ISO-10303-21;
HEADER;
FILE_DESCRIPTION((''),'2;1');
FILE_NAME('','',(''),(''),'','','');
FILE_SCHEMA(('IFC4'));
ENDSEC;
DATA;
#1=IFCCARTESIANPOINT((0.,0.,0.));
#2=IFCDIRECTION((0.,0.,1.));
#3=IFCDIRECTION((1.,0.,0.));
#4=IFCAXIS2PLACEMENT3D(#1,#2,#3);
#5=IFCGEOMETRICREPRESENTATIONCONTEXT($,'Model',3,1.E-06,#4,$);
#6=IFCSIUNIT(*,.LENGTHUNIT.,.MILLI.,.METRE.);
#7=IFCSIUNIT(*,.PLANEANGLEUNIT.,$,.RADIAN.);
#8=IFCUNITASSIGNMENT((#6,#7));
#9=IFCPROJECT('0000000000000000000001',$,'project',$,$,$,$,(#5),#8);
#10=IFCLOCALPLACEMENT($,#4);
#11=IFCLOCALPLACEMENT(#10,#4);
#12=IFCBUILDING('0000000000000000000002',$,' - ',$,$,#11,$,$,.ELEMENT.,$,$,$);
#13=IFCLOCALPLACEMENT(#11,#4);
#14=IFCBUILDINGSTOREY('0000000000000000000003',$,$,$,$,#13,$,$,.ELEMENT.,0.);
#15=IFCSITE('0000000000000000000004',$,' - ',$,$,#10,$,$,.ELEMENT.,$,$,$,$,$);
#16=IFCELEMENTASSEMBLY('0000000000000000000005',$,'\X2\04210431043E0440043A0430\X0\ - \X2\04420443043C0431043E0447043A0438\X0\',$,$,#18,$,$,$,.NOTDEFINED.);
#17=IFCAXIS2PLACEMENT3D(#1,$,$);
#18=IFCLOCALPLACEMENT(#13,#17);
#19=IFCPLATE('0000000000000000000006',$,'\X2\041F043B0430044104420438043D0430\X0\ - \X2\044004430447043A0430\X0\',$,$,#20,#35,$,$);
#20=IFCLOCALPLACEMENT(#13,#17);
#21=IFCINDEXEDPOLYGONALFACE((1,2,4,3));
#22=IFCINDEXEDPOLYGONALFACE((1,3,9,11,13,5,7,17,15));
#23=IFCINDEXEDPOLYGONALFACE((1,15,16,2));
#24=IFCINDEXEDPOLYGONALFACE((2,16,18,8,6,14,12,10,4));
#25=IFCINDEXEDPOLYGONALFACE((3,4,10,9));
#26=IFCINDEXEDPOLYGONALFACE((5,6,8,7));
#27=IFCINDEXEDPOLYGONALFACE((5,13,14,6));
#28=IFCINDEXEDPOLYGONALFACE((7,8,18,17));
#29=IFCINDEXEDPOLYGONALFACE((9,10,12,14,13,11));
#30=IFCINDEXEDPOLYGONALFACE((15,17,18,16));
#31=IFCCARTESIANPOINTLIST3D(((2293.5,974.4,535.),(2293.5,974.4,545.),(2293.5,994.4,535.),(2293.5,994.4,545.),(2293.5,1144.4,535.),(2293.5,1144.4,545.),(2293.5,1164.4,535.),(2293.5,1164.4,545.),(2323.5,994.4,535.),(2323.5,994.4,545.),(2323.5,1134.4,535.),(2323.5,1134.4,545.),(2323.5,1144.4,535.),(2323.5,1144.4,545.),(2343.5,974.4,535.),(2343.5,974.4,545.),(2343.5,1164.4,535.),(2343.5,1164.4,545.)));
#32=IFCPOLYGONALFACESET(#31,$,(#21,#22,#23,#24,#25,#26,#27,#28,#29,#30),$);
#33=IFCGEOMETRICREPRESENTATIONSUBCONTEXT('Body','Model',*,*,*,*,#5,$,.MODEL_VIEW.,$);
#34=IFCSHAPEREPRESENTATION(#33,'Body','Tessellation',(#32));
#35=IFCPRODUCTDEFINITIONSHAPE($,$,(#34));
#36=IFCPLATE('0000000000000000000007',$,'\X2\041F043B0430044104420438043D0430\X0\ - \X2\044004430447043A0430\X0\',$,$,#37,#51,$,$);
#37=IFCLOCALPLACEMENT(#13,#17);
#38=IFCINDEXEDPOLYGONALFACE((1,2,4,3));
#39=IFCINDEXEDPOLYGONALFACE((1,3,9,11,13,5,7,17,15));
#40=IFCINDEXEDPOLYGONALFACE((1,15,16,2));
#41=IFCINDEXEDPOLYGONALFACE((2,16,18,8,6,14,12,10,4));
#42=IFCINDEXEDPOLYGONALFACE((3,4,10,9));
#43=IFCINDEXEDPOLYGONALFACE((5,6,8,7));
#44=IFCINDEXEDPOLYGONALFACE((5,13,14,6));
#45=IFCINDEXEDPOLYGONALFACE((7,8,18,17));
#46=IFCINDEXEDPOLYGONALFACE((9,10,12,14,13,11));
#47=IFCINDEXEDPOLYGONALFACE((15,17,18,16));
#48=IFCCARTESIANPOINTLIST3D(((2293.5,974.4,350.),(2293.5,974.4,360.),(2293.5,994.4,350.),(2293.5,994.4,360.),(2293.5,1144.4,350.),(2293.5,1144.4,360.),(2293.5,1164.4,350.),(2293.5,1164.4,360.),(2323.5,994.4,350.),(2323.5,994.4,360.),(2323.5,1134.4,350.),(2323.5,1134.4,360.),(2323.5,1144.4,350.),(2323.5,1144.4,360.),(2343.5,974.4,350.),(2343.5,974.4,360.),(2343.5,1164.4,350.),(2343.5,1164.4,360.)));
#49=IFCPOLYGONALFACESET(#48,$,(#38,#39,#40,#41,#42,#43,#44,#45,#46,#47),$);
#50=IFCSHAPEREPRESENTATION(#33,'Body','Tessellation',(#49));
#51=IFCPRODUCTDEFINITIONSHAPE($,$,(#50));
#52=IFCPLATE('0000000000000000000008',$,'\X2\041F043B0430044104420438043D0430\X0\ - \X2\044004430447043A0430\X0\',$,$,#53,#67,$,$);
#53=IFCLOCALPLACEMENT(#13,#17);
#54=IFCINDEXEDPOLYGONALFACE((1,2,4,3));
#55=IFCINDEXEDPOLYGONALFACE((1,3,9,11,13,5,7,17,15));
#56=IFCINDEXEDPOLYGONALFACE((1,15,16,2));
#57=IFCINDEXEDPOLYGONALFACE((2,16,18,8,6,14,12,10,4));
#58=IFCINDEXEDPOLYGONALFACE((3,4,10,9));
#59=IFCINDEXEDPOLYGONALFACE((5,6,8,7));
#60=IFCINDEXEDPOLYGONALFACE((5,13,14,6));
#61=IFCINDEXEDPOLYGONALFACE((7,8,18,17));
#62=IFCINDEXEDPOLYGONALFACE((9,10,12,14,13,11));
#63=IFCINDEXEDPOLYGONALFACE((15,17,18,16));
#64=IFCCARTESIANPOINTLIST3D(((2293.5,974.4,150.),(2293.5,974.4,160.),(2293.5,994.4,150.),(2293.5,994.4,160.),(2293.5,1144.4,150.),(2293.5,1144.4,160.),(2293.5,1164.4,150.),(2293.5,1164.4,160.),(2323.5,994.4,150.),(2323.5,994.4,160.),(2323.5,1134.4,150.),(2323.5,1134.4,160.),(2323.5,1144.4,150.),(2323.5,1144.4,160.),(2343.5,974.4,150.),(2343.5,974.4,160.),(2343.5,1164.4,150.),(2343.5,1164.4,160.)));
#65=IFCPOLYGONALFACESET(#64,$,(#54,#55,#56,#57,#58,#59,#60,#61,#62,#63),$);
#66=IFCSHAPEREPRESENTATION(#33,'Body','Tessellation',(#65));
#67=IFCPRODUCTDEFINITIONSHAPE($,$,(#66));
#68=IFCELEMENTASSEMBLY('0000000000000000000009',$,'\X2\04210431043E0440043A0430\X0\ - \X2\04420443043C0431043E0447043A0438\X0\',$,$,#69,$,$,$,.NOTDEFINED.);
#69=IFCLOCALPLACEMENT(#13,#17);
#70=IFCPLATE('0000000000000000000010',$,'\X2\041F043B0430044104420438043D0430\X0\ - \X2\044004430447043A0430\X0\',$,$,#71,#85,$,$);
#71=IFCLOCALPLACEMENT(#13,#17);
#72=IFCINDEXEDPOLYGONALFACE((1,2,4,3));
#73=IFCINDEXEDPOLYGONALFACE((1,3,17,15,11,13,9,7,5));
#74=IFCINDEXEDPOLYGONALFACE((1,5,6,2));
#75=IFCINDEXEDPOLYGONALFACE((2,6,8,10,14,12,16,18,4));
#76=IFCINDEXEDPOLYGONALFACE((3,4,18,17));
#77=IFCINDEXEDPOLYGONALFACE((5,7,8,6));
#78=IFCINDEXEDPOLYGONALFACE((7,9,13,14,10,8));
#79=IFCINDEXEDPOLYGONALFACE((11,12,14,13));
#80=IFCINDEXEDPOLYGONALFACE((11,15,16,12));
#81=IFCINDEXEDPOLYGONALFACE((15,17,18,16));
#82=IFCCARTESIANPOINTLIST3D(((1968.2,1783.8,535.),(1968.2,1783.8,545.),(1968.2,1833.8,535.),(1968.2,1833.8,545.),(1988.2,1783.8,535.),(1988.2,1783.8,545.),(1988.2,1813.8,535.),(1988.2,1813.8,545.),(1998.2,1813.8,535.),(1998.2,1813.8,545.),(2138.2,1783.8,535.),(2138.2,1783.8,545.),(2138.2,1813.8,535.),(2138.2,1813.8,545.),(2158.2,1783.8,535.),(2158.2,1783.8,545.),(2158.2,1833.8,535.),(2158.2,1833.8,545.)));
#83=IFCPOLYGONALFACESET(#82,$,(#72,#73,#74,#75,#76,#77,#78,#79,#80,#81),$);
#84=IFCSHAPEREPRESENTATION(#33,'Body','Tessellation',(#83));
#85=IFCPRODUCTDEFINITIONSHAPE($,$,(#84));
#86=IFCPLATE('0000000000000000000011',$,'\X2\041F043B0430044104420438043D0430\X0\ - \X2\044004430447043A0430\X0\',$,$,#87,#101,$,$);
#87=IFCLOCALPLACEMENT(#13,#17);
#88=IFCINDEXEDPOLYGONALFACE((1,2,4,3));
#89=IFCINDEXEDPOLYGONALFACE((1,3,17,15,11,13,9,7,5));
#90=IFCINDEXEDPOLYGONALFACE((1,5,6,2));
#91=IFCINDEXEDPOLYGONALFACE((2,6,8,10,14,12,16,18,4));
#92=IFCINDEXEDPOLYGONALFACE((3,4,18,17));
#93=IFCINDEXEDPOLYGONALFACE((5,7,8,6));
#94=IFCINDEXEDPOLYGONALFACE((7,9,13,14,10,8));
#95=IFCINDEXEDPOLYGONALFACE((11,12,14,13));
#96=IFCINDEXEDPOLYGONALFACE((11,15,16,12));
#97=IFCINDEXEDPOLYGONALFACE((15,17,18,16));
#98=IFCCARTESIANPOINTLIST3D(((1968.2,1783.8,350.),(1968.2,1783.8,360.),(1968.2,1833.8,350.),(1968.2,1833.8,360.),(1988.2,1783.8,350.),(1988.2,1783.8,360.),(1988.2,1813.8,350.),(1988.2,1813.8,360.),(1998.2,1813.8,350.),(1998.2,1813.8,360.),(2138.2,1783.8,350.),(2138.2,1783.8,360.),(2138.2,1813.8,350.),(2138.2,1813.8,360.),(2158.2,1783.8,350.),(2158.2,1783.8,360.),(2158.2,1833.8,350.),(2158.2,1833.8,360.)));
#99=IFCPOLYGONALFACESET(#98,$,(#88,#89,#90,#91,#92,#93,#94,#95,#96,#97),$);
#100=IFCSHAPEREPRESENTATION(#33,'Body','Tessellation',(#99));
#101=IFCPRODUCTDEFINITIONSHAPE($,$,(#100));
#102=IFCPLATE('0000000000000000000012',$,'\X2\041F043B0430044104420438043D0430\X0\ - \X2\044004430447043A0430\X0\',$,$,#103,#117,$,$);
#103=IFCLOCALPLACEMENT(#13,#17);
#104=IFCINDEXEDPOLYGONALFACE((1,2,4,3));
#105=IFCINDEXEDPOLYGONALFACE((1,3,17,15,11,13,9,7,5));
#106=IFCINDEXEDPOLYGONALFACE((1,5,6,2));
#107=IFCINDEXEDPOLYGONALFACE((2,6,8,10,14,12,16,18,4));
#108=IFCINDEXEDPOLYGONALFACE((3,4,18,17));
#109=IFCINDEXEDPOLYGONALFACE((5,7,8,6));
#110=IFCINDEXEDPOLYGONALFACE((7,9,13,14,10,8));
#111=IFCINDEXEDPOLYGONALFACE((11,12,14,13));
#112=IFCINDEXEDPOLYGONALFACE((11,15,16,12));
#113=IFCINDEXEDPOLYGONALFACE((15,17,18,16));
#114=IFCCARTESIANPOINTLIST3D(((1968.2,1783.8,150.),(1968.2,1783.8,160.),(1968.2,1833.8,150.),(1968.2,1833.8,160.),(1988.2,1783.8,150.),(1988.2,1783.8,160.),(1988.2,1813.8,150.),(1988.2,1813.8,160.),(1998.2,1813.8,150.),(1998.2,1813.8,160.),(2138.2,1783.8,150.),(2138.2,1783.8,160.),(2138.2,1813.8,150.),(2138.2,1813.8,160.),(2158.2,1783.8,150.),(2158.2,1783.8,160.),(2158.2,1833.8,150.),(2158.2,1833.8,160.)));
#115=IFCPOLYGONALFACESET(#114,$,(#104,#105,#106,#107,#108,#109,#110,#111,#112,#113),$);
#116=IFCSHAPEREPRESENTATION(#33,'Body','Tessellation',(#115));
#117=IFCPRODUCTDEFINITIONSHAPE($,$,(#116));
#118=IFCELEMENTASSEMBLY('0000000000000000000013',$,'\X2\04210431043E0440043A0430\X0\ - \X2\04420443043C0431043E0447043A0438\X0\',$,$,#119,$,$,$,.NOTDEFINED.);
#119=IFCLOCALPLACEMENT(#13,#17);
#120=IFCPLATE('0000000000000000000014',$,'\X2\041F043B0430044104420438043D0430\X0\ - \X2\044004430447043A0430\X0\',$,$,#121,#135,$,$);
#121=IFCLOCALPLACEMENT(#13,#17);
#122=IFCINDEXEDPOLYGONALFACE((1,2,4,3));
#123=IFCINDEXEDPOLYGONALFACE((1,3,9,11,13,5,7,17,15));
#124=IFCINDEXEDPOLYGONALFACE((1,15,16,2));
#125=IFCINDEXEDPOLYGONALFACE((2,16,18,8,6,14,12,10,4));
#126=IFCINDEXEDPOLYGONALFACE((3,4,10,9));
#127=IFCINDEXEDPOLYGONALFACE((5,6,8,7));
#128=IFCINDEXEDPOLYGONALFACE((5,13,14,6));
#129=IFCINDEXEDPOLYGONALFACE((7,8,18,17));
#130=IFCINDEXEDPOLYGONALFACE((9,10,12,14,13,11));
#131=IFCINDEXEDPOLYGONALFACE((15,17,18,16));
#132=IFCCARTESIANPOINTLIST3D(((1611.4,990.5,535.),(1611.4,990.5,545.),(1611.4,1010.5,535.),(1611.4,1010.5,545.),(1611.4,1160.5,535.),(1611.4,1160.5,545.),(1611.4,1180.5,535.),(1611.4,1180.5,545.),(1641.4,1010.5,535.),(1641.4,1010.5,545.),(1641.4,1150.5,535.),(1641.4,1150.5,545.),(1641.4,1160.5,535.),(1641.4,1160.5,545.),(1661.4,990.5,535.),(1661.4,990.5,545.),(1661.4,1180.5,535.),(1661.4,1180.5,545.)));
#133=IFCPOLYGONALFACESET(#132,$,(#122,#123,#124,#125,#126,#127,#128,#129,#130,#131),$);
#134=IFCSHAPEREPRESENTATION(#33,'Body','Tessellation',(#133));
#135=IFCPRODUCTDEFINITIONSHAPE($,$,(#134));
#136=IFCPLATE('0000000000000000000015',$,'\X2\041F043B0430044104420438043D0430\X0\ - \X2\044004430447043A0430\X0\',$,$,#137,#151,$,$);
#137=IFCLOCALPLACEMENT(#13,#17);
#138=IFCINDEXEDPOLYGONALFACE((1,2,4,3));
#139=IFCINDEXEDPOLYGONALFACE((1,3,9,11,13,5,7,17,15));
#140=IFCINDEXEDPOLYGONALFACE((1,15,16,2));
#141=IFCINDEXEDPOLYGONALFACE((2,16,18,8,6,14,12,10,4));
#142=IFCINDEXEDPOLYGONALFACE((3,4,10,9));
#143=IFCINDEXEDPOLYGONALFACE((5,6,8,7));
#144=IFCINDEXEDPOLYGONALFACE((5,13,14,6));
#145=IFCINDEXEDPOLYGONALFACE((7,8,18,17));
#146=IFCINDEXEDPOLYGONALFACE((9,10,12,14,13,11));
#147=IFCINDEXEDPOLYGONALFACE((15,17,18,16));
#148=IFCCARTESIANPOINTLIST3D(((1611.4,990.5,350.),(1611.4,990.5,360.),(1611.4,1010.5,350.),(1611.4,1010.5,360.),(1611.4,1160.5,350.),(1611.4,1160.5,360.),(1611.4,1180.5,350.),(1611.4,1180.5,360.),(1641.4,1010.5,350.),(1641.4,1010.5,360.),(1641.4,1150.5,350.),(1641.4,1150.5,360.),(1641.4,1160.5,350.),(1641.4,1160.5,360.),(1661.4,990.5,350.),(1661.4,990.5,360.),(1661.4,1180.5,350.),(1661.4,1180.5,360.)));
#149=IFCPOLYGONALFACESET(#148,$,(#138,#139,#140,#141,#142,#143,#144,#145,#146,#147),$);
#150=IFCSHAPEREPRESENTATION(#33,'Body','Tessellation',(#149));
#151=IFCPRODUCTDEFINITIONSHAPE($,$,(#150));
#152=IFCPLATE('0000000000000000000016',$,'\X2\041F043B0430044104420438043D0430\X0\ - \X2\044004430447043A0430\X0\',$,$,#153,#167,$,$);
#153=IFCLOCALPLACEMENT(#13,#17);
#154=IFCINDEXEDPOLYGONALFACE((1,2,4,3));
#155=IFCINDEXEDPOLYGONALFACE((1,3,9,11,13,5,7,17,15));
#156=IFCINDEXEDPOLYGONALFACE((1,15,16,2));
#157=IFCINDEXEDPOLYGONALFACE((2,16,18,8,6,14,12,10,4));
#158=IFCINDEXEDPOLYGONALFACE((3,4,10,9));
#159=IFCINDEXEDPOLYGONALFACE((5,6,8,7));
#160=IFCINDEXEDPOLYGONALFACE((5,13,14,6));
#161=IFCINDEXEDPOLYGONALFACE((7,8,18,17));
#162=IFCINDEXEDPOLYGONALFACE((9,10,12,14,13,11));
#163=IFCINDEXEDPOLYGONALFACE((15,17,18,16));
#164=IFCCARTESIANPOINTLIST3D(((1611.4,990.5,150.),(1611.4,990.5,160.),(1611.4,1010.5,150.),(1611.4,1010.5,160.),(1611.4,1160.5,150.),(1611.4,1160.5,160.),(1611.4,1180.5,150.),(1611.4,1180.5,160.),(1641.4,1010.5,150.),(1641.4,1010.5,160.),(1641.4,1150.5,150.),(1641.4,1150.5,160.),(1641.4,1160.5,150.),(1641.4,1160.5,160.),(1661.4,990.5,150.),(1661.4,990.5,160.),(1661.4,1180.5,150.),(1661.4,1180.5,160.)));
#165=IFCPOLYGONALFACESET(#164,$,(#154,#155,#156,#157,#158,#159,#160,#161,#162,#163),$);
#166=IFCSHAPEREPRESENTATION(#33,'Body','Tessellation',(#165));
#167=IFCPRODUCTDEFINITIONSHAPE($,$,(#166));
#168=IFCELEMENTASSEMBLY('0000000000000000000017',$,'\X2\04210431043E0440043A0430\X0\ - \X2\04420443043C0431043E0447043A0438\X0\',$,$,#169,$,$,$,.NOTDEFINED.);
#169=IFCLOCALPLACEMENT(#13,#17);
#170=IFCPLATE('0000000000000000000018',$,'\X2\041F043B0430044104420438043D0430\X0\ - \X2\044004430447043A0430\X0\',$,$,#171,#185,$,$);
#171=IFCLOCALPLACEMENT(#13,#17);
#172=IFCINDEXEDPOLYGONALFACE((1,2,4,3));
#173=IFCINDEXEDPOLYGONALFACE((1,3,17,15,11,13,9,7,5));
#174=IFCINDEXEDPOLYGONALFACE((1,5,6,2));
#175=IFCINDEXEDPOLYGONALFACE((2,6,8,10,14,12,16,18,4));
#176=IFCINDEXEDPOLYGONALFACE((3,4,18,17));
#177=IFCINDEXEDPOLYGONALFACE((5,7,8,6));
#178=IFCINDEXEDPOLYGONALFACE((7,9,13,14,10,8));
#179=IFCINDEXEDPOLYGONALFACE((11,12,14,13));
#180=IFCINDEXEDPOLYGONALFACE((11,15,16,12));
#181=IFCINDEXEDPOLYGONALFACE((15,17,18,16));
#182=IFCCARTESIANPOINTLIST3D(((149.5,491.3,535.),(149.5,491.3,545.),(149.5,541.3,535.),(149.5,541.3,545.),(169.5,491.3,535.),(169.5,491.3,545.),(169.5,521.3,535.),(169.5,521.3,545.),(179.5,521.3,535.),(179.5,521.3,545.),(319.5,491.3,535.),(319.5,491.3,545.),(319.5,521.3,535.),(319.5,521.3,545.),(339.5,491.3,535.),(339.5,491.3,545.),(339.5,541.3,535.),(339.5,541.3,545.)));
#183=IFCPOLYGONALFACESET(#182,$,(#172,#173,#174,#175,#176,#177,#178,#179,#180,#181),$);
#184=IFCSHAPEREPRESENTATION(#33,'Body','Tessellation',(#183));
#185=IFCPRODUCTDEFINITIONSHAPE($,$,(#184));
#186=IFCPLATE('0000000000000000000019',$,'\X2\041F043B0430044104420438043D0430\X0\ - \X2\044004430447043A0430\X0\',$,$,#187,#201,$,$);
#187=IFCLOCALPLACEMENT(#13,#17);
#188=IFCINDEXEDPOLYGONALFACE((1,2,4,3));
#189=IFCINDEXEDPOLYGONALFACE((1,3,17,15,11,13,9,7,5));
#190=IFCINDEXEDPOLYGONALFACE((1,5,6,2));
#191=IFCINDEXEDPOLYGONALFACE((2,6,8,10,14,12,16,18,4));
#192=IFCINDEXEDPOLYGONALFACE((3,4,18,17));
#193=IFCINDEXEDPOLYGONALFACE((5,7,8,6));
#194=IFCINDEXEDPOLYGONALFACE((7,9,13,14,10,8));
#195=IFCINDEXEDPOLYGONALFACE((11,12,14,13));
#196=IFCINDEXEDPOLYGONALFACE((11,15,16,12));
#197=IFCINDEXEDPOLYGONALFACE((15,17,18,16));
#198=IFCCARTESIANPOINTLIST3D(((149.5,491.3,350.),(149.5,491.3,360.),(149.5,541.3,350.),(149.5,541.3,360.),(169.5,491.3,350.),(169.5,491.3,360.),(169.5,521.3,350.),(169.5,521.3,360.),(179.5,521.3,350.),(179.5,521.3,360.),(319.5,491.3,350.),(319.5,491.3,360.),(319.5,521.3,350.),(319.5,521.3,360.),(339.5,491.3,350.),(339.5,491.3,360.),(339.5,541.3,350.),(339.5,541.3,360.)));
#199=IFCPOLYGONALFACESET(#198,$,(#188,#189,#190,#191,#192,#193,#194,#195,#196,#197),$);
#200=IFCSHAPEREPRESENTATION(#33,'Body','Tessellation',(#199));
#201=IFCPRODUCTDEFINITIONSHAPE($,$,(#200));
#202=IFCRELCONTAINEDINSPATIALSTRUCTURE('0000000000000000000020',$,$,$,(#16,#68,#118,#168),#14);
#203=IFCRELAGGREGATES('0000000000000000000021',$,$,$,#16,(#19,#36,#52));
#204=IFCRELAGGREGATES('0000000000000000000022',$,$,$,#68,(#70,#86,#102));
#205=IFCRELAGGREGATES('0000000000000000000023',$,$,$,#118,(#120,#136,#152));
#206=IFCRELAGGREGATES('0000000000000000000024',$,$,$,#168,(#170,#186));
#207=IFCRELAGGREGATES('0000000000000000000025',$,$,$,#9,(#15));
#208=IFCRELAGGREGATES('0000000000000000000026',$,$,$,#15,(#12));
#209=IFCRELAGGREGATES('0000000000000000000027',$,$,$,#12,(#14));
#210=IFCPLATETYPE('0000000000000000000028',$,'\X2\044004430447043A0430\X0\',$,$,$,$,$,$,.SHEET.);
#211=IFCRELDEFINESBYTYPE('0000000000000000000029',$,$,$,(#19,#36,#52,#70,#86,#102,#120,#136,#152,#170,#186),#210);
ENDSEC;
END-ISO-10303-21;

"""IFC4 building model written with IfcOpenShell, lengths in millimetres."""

from ifc_helpers import new_model, si_unit, frame, origin_with_axes, place, context, subcontext, project, spatial, line, indexed_curve, outline, extrude, source, transform, mapped, type_object, element, aggregate, save


model = new_model("IFC4")

# Units and contexts
model_context = context("Model", 3, precision=1e-06, world=origin_with_axes())
body_context = subcontext(model_context, "Body", "Model", "MODEL_VIEW")
ifc_project = project(units=[si_unit("LENGTHUNIT", "METRE", prefix="MILLI"), si_unit("PLANEANGLEUNIT", "RADIAN")], contexts=[model_context])

# Site, building, storey
site_placement = place(None, origin_with_axes())
site = spatial("IfcSite", under=ifc_project, at=site_placement, Name=" - ", CompositionType="ELEMENT")
building_placement = place(site_placement, origin_with_axes())
building = spatial("IfcBuilding", under=site, at=building_placement, Name=" - ", CompositionType="ELEMENT")
storey_placement = place(building_placement, origin_with_axes())
storey = spatial("IfcBuildingStorey", under=building, at=storey_placement, CompositionType="ELEMENT", Elevation=0.0)

# Shared definitions
plate_type = type_object("IfcPlateType", Name="ручка", PredefinedType="SHEET")
shared_shape_1 = source(origin_with_axes(), body_context, "Body", "SweptSolid", [
    extrude(outline(indexed_curve([(-95.0, -25.0), (-75.0, -25.0), (-75.0, 5.0), (-65.0, 5.0), (75.0, 5.0), (75.0, -25.0), (95.0, -25.0), (95.0, 25.0), (-95.0, 25.0)], segments=[line(1, 2), line(2, 3), line(3, 4), line(4, 5), line(5, 6), line(6, 7), line(7, 8), line(8, 9), line(9, 1)])), origin_with_axes(), (0.0, 0.0, 1.0), 10.0),
])

# Element assemblies, plates
assembly_1_placement = place(storey_placement, frame((2293.5, 869.4, 0.0), z_axis=(0.0, 0.0, 1.0), x_axis=(0.0, 1.0, 0.0)))
assembly_1 = element("IfcElementAssembly", 1, at=assembly_1_placement, inside=storey, Name="Сборка - тумбочки", PredefinedType="NOTDEFINED")
plate_1_placement = place(assembly_1_placement, frame((200.0, -25.0, 535.0), z_axis=(0.0, 0.0, 1.0), x_axis=(-1.0, 0.0, 0.0)))
plate_1 = element("IfcPlate", 2, at=plate_1_placement, type_object=plate_type, Name="Пластина - ручка", context=body_context, shape_type="MappedRepresentation", body=[
    mapped(shared_shape_1, transform((0.0, 0.0, 0.0), x_axis=(1.0, 0.0, 0.0), y_axis=(0.0, 1.0, 0.0), z_axis=(0.0, 0.0, 1.0), scale=1.0)),
])
plate_2_placement = place(assembly_1_placement, frame((200.0, -25.0, 350.0), z_axis=(0.0, 0.0, 1.0), x_axis=(-1.0, 0.0, 0.0)))
plate_2 = element("IfcPlate", 3, at=plate_2_placement, type_object=plate_type, Name="Пластина - ручка", context=body_context, shape_type="MappedRepresentation", body=[
    mapped(shared_shape_1, transform((0.0, 0.0, 0.0), x_axis=(1.0, 0.0, 0.0), y_axis=(0.0, 1.0, 0.0), z_axis=(0.0, 0.0, 1.0), scale=1.0)),
])
plate_3_placement = place(assembly_1_placement, frame((200.0, -25.0, 150.0), z_axis=(0.0, 0.0, 1.0), x_axis=(-1.0, 0.0, 0.0)))
plate_3 = element("IfcPlate", 4, at=plate_3_placement, type_object=plate_type, Name="Пластина - ручка", context=body_context, shape_type="MappedRepresentation", body=[
    mapped(shared_shape_1, transform((0.0, 0.0, 0.0), x_axis=(1.0, 0.0, 0.0), y_axis=(0.0, 1.0, 0.0), z_axis=(0.0, 0.0, 1.0), scale=1.0)),
])
aggregate(assembly_1, [plate_1, plate_2, plate_3])
assembly_2_placement = place(storey_placement, frame((2263.2, 1783.8, 0.0), z_axis=(0.0, 0.0, 1.0), x_axis=(-1.0, 0.0, 0.0)))
assembly_2 = element("IfcElementAssembly", 5, at=assembly_2_placement, inside=storey, Name="Сборка - тумбочки", PredefinedType="NOTDEFINED")
plate_4_placement = place(assembly_2_placement, frame((200.0, -25.0, 535.0), z_axis=(0.0, 0.0, 1.0), x_axis=(-1.0, 0.0, 0.0)))
plate_4 = element("IfcPlate", 6, at=plate_4_placement, type_object=plate_type, Name="Пластина - ручка", context=body_context, shape_type="MappedRepresentation", body=[
    mapped(shared_shape_1, transform((0.0, 0.0, 0.0), x_axis=(1.0, 0.0, 0.0), y_axis=(0.0, 1.0, 0.0), z_axis=(0.0, 0.0, 1.0), scale=1.0)),
])
plate_5_placement = place(assembly_2_placement, frame((200.0, -25.0, 350.0), z_axis=(0.0, 0.0, 1.0), x_axis=(-1.0, 0.0, 0.0)))
plate_5 = element("IfcPlate", 7, at=plate_5_placement, type_object=plate_type, Name="Пластина - ручка", context=body_context, shape_type="MappedRepresentation", body=[
    mapped(shared_shape_1, transform((0.0, 0.0, 0.0), x_axis=(1.0, 0.0, 0.0), y_axis=(0.0, 1.0, 0.0), z_axis=(0.0, 0.0, 1.0), scale=1.0)),
])
plate_6_placement = place(assembly_2_placement, frame((200.0, -25.0, 150.0), z_axis=(0.0, 0.0, 1.0), x_axis=(-1.0, 0.0, 0.0)))
plate_6 = element("IfcPlate", 8, at=plate_6_placement, type_object=plate_type, Name="Пластина - ручка", context=body_context, shape_type="MappedRepresentation", body=[
    mapped(shared_shape_1, transform((0.0, 0.0, 0.0), x_axis=(1.0, 0.0, 0.0), y_axis=(0.0, 1.0, 0.0), z_axis=(0.0, 0.0, 1.0), scale=1.0)),
])
aggregate(assembly_2, [plate_4, plate_5, plate_6])
assembly_3_placement = place(storey_placement, frame((1611.4, 885.5, 0.0), z_axis=(0.0, 0.0, 1.0), x_axis=(0.0, 1.0, 0.0)))
assembly_3 = element("IfcElementAssembly", 9, at=assembly_3_placement, inside=storey, Name="Сборка - тумбочки", PredefinedType="NOTDEFINED")
plate_7_placement = place(assembly_3_placement, frame((200.0, -25.0, 535.0), z_axis=(0.0, 0.0, 1.0), x_axis=(-1.0, 0.0, 0.0)))
plate_7 = element("IfcPlate", 10, at=plate_7_placement, type_object=plate_type, Name="Пластина - ручка", context=body_context, shape_type="MappedRepresentation", body=[
    mapped(shared_shape_1, transform((0.0, 0.0, 0.0), x_axis=(1.0, 0.0, 0.0), y_axis=(0.0, 1.0, 0.0), z_axis=(0.0, 0.0, 1.0), scale=1.0)),
])
plate_8_placement = place(assembly_3_placement, frame((200.0, -25.0, 350.0), z_axis=(0.0, 0.0, 1.0), x_axis=(-1.0, 0.0, 0.0)))
plate_8 = element("IfcPlate", 11, at=plate_8_placement, type_object=plate_type, Name="Пластина - ручка", context=body_context, shape_type="MappedRepresentation", body=[
    mapped(shared_shape_1, transform((0.0, 0.0, 0.0), x_axis=(1.0, 0.0, 0.0), y_axis=(0.0, 1.0, 0.0), z_axis=(0.0, 0.0, 1.0), scale=1.0)),
])
plate_9_placement = place(assembly_3_placement, frame((200.0, -25.0, 150.0), z_axis=(0.0, 0.0, 1.0), x_axis=(-1.0, 0.0, 0.0)))
plate_9 = element("IfcPlate", 12, at=plate_9_placement, type_object=plate_type, Name="Пластина - ручка", context=body_context, shape_type="MappedRepresentation", body=[
    mapped(shared_shape_1, transform((0.0, 0.0, 0.0), x_axis=(1.0, 0.0, 0.0), y_axis=(0.0, 1.0, 0.0), z_axis=(0.0, 0.0, 1.0), scale=1.0)),
])
aggregate(assembly_3, [plate_7, plate_8, plate_9])
assembly_4_placement = place(storey_placement, frame((444.5, 491.3, 0.0), z_axis=(0.0, 0.0, 1.0), x_axis=(-1.0, 0.0, 0.0)))
assembly_4 = element("IfcElementAssembly", 13, at=assembly_4_placement, inside=storey, Name="Сборка - тумбочки", PredefinedType="NOTDEFINED")
plate_10_placement = place(assembly_4_placement, frame((200.0, -25.0, 535.0), z_axis=(0.0, 0.0, 1.0), x_axis=(-1.0, 0.0, 0.0)))
plate_10 = element("IfcPlate", 14, at=plate_10_placement, type_object=plate_type, Name="Пластина - ручка", context=body_context, shape_type="MappedRepresentation", body=[
    mapped(shared_shape_1, transform((0.0, 0.0, 0.0), x_axis=(1.0, 0.0, 0.0), y_axis=(0.0, 1.0, 0.0), z_axis=(0.0, 0.0, 1.0), scale=1.0)),
])
plate_11_placement = place(assembly_4_placement, frame((200.0, -25.0, 350.0), z_axis=(0.0, 0.0, 1.0), x_axis=(-1.0, 0.0, 0.0)))
plate_11 = element("IfcPlate", 15, at=plate_11_placement, type_object=plate_type, Name="Пластина - ручка", context=body_context, shape_type="MappedRepresentation", body=[
    mapped(shared_shape_1, transform((0.0, 0.0, 0.0), x_axis=(1.0, 0.0, 0.0), y_axis=(0.0, 1.0, 0.0), z_axis=(0.0, 0.0, 1.0), scale=1.0)),
])
aggregate(assembly_4, [plate_10, plate_11])

save(model, "model.ifc")
